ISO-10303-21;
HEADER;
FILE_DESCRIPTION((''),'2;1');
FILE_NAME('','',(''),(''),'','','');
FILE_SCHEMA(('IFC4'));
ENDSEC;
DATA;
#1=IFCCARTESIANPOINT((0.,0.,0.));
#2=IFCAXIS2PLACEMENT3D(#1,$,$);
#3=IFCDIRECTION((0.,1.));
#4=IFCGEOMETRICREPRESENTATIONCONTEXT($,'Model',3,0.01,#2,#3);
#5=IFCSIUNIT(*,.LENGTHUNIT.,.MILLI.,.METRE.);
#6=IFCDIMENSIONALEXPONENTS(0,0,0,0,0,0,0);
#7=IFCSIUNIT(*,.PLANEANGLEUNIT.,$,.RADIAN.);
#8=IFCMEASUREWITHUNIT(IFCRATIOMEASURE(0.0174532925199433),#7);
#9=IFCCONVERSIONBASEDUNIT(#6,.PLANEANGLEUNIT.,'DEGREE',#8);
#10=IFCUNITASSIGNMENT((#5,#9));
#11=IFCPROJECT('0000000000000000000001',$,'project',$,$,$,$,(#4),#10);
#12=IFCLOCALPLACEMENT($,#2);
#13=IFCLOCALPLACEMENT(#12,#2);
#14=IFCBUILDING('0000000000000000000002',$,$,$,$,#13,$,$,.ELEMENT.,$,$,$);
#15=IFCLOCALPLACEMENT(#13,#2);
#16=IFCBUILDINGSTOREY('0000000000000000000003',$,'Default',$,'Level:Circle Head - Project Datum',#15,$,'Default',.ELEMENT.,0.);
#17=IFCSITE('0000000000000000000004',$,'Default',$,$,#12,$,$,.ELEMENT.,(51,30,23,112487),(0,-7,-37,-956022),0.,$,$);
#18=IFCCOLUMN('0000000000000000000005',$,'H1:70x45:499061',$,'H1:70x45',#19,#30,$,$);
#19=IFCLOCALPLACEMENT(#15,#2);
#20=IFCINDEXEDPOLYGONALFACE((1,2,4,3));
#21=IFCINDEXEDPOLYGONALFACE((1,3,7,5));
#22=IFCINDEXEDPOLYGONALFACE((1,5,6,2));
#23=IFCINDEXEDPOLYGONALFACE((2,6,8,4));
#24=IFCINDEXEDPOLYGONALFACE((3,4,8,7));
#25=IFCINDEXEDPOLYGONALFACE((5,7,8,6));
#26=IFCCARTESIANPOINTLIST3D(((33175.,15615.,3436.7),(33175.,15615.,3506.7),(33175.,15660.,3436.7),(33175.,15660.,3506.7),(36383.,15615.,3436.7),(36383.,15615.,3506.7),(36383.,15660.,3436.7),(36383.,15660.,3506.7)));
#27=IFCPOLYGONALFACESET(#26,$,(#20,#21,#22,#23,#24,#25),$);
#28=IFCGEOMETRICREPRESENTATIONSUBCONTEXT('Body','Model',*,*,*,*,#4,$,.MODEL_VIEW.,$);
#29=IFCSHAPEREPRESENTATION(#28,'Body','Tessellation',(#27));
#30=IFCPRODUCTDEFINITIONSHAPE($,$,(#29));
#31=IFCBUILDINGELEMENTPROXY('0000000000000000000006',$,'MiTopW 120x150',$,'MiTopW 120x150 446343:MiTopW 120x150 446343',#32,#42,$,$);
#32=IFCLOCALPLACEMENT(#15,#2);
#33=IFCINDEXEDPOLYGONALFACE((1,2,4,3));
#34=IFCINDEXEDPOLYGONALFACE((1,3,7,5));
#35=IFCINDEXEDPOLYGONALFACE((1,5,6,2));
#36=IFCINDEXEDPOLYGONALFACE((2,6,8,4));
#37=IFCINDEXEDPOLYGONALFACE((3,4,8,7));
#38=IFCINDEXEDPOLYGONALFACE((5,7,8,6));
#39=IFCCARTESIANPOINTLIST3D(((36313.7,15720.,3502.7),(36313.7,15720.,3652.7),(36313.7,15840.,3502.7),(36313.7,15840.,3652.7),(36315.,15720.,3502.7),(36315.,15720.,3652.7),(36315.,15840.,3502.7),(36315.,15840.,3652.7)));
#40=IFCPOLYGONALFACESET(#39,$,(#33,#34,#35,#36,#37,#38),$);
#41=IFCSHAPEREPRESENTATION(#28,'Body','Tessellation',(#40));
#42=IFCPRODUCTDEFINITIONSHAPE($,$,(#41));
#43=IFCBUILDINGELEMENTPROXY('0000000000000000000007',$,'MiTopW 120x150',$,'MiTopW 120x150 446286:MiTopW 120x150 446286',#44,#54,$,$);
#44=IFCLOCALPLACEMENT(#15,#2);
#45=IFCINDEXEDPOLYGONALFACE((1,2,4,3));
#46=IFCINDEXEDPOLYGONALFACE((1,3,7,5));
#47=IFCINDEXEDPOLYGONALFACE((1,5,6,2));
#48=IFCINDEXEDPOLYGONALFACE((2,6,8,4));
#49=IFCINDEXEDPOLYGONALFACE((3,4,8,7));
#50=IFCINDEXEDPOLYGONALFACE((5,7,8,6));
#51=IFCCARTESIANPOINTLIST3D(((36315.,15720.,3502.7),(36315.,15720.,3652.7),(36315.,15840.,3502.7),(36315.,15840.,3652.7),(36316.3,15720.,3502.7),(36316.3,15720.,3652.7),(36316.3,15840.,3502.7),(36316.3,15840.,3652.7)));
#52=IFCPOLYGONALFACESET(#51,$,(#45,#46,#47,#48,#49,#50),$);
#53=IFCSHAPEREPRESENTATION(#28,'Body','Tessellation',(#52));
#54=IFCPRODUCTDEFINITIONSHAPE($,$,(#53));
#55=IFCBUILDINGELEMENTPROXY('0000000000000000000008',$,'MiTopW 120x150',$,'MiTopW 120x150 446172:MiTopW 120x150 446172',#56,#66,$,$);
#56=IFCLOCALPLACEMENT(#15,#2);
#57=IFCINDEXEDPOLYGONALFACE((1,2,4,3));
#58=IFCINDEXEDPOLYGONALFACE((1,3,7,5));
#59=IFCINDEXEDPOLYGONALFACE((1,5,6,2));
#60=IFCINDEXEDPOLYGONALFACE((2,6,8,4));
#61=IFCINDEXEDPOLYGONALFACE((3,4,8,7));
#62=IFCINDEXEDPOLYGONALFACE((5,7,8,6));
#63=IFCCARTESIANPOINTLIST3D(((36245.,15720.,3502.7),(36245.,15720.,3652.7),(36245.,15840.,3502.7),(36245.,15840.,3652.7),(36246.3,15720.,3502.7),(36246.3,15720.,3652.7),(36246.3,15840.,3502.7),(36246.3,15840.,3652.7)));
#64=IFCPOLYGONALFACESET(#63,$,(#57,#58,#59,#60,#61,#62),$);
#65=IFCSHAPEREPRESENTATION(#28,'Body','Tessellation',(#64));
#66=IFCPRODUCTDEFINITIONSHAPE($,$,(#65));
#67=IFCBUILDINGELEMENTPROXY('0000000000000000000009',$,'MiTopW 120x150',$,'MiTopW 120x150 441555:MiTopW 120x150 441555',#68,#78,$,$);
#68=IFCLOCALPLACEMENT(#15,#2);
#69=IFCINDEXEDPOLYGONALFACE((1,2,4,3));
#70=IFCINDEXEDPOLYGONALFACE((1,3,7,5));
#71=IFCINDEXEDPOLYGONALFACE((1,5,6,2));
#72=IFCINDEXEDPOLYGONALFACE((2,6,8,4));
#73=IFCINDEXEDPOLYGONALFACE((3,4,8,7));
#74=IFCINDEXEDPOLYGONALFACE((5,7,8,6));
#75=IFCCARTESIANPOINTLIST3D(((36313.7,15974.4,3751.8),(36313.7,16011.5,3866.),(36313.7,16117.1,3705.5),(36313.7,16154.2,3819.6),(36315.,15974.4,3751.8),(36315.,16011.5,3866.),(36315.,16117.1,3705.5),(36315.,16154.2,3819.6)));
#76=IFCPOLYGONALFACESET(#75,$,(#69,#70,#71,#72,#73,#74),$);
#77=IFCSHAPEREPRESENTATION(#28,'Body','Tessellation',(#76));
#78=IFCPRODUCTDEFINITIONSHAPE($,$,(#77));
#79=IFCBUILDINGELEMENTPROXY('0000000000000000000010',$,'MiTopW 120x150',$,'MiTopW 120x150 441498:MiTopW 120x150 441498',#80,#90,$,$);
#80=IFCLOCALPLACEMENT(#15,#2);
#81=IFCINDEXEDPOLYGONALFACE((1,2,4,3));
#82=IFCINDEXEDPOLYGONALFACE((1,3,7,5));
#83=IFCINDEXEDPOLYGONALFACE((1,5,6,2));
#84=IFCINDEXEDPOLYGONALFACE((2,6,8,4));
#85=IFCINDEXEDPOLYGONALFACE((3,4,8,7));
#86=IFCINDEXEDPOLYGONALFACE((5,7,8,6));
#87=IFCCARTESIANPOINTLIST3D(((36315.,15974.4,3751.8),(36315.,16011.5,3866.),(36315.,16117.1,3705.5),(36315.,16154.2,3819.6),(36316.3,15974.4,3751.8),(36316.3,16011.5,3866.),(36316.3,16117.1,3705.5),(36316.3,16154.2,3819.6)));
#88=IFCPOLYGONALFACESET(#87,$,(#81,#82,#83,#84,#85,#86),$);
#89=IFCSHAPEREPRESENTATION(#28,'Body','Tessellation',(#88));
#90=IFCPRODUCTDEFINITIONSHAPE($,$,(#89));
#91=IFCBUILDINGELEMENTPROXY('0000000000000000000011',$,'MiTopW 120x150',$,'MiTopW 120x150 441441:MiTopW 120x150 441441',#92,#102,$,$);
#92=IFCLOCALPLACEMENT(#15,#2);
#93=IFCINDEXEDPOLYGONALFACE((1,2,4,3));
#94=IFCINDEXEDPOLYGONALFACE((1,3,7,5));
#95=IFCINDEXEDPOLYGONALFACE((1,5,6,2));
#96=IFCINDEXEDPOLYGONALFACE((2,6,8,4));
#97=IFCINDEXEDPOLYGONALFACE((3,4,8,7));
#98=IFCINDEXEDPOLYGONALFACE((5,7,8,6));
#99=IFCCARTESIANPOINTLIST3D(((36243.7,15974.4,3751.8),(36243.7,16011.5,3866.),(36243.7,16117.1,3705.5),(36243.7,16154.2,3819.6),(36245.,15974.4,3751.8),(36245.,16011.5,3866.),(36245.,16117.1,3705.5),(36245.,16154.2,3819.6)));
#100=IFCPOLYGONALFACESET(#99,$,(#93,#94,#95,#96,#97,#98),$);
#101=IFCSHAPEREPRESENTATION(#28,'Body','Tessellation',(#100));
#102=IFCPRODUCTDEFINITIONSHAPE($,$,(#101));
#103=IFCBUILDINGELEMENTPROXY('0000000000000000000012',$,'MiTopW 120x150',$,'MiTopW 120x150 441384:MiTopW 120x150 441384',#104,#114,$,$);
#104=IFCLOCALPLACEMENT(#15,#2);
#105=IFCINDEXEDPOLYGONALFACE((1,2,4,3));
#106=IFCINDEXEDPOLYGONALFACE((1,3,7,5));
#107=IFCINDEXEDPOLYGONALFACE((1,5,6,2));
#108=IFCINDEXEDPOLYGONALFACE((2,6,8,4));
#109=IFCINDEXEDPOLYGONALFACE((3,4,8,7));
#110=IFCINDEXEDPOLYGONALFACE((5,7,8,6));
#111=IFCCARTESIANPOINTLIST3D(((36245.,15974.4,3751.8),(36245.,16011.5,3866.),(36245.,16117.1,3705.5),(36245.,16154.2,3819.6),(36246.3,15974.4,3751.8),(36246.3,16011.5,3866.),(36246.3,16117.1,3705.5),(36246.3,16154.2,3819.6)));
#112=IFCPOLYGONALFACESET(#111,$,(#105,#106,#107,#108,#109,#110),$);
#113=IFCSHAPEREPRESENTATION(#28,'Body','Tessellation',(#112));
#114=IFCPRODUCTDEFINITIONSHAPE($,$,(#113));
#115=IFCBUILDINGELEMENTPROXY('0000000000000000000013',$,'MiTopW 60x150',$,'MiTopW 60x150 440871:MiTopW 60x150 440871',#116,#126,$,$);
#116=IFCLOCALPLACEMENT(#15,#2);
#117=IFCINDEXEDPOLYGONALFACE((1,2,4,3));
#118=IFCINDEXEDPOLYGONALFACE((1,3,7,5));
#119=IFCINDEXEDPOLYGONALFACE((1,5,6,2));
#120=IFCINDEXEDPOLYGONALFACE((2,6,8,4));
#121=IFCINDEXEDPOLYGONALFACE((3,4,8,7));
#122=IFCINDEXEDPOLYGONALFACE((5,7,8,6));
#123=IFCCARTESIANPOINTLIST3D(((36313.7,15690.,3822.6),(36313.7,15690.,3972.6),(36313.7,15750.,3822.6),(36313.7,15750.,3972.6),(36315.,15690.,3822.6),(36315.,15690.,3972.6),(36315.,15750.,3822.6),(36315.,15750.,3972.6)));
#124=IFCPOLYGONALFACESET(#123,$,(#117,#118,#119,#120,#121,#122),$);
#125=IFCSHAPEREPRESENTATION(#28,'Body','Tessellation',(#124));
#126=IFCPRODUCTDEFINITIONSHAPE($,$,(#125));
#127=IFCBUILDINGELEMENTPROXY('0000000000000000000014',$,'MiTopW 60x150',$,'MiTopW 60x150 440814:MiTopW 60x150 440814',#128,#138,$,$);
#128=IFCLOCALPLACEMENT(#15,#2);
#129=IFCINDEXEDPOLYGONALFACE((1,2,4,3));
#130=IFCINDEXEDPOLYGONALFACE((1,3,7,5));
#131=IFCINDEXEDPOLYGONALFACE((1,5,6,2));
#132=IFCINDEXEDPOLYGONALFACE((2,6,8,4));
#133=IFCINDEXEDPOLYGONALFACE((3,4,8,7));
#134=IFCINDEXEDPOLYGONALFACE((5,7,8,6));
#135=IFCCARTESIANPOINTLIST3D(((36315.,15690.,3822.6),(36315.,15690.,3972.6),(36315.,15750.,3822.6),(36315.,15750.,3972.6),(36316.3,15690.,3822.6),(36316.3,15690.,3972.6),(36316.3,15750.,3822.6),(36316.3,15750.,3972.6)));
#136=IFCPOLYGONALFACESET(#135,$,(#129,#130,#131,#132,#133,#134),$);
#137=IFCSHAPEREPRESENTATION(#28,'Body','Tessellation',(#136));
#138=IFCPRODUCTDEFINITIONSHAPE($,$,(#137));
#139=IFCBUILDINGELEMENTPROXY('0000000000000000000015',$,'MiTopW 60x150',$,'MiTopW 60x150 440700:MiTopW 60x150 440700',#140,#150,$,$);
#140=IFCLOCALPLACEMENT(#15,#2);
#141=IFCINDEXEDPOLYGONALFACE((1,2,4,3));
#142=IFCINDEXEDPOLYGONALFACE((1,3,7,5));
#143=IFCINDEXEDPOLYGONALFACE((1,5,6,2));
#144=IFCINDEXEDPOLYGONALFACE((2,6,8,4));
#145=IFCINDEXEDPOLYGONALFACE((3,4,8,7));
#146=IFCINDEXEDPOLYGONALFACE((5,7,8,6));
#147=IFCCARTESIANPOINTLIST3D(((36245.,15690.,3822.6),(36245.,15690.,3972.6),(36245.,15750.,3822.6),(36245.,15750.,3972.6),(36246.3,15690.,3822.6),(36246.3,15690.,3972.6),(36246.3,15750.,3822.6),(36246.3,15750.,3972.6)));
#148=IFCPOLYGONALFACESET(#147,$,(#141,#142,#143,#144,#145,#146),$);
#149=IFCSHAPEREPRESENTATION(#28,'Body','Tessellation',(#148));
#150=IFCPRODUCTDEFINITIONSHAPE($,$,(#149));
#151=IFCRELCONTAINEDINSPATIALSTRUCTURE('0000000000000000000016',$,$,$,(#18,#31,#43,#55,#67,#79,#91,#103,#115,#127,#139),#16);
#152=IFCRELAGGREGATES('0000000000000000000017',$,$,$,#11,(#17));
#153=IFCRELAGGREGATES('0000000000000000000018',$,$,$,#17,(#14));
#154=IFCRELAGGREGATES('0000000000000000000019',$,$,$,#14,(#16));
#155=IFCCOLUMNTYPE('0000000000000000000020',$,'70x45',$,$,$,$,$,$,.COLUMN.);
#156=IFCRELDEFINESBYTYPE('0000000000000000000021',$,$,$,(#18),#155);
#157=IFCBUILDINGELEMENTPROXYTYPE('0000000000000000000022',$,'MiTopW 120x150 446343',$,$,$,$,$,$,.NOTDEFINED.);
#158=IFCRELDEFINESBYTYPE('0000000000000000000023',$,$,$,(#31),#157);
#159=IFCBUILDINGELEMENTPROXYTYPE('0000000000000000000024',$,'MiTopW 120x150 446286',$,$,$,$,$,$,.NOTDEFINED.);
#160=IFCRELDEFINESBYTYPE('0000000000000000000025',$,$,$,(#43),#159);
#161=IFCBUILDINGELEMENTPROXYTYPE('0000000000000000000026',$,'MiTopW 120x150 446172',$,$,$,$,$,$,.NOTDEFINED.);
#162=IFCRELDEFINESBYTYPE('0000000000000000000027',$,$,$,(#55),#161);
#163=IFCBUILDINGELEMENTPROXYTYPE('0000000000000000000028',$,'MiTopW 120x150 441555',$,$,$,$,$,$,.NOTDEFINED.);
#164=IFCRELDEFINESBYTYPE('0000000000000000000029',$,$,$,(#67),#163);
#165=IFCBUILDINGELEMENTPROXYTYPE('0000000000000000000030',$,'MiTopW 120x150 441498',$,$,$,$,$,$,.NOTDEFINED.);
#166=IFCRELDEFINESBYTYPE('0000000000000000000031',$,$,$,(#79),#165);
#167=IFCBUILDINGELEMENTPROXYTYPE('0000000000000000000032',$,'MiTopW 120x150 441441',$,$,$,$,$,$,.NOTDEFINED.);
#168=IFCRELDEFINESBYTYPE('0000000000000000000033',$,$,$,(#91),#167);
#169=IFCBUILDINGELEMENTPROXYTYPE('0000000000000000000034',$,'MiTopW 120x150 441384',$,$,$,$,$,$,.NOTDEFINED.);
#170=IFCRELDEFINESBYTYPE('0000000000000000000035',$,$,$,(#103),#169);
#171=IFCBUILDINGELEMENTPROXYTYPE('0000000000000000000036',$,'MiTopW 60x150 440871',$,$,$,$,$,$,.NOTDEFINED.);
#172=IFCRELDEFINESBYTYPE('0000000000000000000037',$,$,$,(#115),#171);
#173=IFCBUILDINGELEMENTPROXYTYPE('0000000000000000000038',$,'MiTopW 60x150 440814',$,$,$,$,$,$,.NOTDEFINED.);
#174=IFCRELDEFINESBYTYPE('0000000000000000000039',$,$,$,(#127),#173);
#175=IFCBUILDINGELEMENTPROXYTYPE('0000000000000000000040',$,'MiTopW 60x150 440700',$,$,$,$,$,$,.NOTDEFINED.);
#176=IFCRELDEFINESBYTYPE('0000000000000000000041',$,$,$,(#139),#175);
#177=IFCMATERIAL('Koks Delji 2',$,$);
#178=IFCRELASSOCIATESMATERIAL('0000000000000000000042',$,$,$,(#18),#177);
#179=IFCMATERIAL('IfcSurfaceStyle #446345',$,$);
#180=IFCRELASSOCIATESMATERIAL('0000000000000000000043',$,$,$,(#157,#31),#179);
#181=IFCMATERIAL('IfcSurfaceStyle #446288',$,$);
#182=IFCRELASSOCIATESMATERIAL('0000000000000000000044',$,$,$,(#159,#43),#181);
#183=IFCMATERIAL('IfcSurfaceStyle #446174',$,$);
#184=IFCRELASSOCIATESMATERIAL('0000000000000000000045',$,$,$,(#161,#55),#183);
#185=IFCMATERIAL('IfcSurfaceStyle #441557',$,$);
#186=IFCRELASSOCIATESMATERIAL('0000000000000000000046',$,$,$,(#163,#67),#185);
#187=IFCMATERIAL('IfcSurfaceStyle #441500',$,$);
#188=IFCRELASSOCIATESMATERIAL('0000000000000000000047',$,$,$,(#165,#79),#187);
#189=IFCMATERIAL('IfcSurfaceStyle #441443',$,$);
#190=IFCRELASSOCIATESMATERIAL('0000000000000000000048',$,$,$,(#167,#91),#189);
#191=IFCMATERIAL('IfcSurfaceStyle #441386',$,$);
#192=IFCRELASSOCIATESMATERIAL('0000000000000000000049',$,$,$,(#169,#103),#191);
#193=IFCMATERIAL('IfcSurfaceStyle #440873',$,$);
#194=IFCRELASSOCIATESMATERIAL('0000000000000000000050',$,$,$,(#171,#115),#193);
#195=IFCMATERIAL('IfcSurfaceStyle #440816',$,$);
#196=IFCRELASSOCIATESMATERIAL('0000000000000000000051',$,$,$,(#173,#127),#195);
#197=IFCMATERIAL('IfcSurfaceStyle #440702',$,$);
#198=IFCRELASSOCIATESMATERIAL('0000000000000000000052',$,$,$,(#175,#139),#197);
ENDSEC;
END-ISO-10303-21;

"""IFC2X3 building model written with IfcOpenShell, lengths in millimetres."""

from ifc_helpers import new_model, entity, si_unit, converted_unit, direction, frame, frame_2d, origin, origin_2d_with_axis, place, context, subcontext, project, spatial, polyline, rectangle, outline, extrude, source, transform, mapped, material, type_object, type_shapes, element, save


model = new_model("IFC2X3")

# Units and contexts
model_context = context("Model", 3, precision=0.01, world=origin(), true_north=direction((0.0, 1.0)))
body_context = subcontext(model_context, "Body", "Model", "MODEL_VIEW")
ifc_project = project(units=[si_unit("LENGTHUNIT", "METRE", prefix="MILLI"), converted_unit("PLANEANGLEUNIT", "DEGREE", entity("IfcRatioMeasure", 0.0174532925199433), si_unit("PLANEANGLEUNIT", "RADIAN"), dimensions=[0, 0, 0, 0, 0, 0, 0])], contexts=[model_context])

# Site, building, storey
site_placement = place(None, origin())
site = spatial("IfcSite", under=ifc_project, at=site_placement, Name="Default", CompositionType="ELEMENT", RefLatitude=(51, 30, 23, 112487), RefLongitude=(0, -7, -37, -956022), RefElevation=0.0)
building_placement = place(site_placement, origin())
building = spatial("IfcBuilding", under=site, at=building_placement, CompositionType="ELEMENT")
storey_placement = place(building_placement, origin())
storey = spatial("IfcBuildingStorey", under=building, at=storey_placement, Name="Default", ObjectType="Level:Circle Head - Project Datum", LongName="Default", CompositionType="ELEMENT", Elevation=0.0)

# Column
ifc_material_1 = material(Name="Koks Delji 2")
column_type = type_object("IfcColumnType", Name="70x45", PredefinedType="COLUMN")
shared_shape_1 = source(origin(), body_context, "Body", "SweptSolid", [
    extrude(rectangle(XDim=45.0, YDim=3208.0, at=frame_2d((0.0, 0.0), x_axis=(1.0, 0.0))), frame((1604.0, 250.3, 0.0), z_axis=(0.0, 0.0, 1.0), x_axis=(0.0, -1.0, 0.0)), (0.0, 0.0, 1.0), 70.0),
])
type_shapes(column_type, [shared_shape_1])
column_placement = place(storey_placement, frame((36383.0, 15887.8, 3436.7), z_axis=(0.0, 0.0, 1.0), x_axis=(-1.0, 0.0, 0.0)))
element("IfcColumn", 1, at=column_placement, inside=storey, type_object=column_type, material=ifc_material_1, Name="H1:70x45:499061", ObjectType="H1:70x45", context=body_context, shape_type="MappedRepresentation", body=[
    mapped(shared_shape_1, transform((0.0, 0.0, 0.0), scale=1.0)),
])

# Building element proxies
ifc_material_2 = material(Name="IfcSurfaceStyle #446345")
building_element_proxy_type_1 = type_object("IfcBuildingElementProxyType", Name="MiTopW 120x150 446343", PredefinedType="NOTDEFINED", material=ifc_material_2)
shared_shape_2 = source(origin(), body_context, "Body", "SweptSolid", [
    extrude(rectangle(XDim=150.0, YDim=120.0, at=origin_2d_with_axis()), frame((75.0, 60.0, 0.0), z_axis=(0.0, 0.0, 1.0), x_axis=(-1.0, 0.0, 0.0)), (0.0, 0.0, 1.0), 1.3),
])
type_shapes(building_element_proxy_type_1, [shared_shape_2])
proxy_1_placement = place(building_placement, frame((36315.0, 15840.0, 3652.7), z_axis=(-1.0, 0.0, 0.0), x_axis=(0.0, 0.0, -1.0)))
element("IfcBuildingElementProxy", 2, at=proxy_1_placement, inside=storey, type_object=building_element_proxy_type_1, material=ifc_material_2, Name="MiTopW 120x150", ObjectType="MiTopW 120x150 446343:MiTopW 120x150 446343", context=body_context, shape_type="MappedRepresentation", body=[
    mapped(shared_shape_2, transform((0.0, 0.0, 0.0), scale=1.0)),
])
ifc_material_3 = material(Name="IfcSurfaceStyle #446288")
building_element_proxy_type_2 = type_object("IfcBuildingElementProxyType", Name="MiTopW 120x150 446286", PredefinedType="NOTDEFINED", material=ifc_material_3)
shared_shape_3 = source(origin(), body_context, "Body", "SweptSolid", [
    extrude(rectangle(XDim=150.0, YDim=120.0, at=origin_2d_with_axis()), frame((75.0, 60.0, 0.0), z_axis=(0.0, 0.0, 1.0), x_axis=(-1.0, 0.0, 0.0)), (0.0, 0.0, 1.0), 1.3),
])
type_shapes(building_element_proxy_type_2, [shared_shape_3])
proxy_2_placement = place(building_placement, frame((36316.3, 15840.0, 3652.7), z_axis=(-1.0, 0.0, 0.0), x_axis=(0.0, 0.0, -1.0)))
element("IfcBuildingElementProxy", 3, at=proxy_2_placement, inside=storey, type_object=building_element_proxy_type_2, material=ifc_material_3, Name="MiTopW 120x150", ObjectType="MiTopW 120x150 446286:MiTopW 120x150 446286", context=body_context, shape_type="MappedRepresentation", body=[
    mapped(shared_shape_3, transform((0.0, 0.0, 0.0), scale=1.0)),
])
ifc_material_4 = material(Name="IfcSurfaceStyle #446174")
building_element_proxy_type_3 = type_object("IfcBuildingElementProxyType", Name="MiTopW 120x150 446172", PredefinedType="NOTDEFINED", material=ifc_material_4)
shared_shape_4 = source(origin(), body_context, "Body", "SweptSolid", [
    extrude(rectangle(XDim=150.0, YDim=120.0, at=origin_2d_with_axis()), frame((75.0, 60.0, 0.0), z_axis=(0.0, 0.0, 1.0), x_axis=(-1.0, 0.0, 0.0)), (0.0, 0.0, 1.0), 1.3),
])
type_shapes(building_element_proxy_type_3, [shared_shape_4])
proxy_3_placement = place(building_placement, frame((36246.3, 15840.0, 3652.7), z_axis=(-1.0, 0.0, 0.0), x_axis=(0.0, 0.0, -1.0)))
element("IfcBuildingElementProxy", 4, at=proxy_3_placement, inside=storey, type_object=building_element_proxy_type_3, material=ifc_material_4, Name="MiTopW 120x150", ObjectType="MiTopW 120x150 446172:MiTopW 120x150 446172", context=body_context, shape_type="MappedRepresentation", body=[
    mapped(shared_shape_4, transform((0.0, 0.0, 0.0), scale=1.0)),
])
ifc_material_5 = material(Name="IfcSurfaceStyle #441557")
building_element_proxy_type_4 = type_object("IfcBuildingElementProxyType", Name="MiTopW 120x150 441555", PredefinedType="NOTDEFINED", material=ifc_material_5)
shared_shape_5 = source(origin(), body_context, "Body", "SweptSolid", [
    extrude(outline(polyline([(-75.0, -60.0), (75.0, -60.0), (75.0, 60.0), (-75.0, 60.0), (-75.0, -60.0)])), frame((75.0, 60.0, 0.0), z_axis=(0.0, 0.0, 1.0), x_axis=(-1.0, 0.0, 0.0)), (0.0, 0.0, 1.0), 1.3),
])
type_shapes(building_element_proxy_type_4, [shared_shape_5])
proxy_4_placement = place(building_placement, frame((36315.0, 16117.1, 3705.5), z_axis=(-1.0, 0.0, 0.0), x_axis=(0.0, -0.951057, 0.309017)))
element("IfcBuildingElementProxy", 5, at=proxy_4_placement, inside=storey, type_object=building_element_proxy_type_4, material=ifc_material_5, Name="MiTopW 120x150", ObjectType="MiTopW 120x150 441555:MiTopW 120x150 441555", context=body_context, shape_type="MappedRepresentation", body=[
    mapped(shared_shape_5, transform((0.0, 0.0, 0.0), scale=1.0)),
])
ifc_material_6 = material(Name="IfcSurfaceStyle #441500")
building_element_proxy_type_5 = type_object("IfcBuildingElementProxyType", Name="MiTopW 120x150 441498", PredefinedType="NOTDEFINED", material=ifc_material_6)
shared_shape_6 = source(origin(), body_context, "Body", "SweptSolid", [
    extrude(outline(polyline([(-75.0, -60.0), (75.0, -60.0), (75.0, 60.0), (-75.0, 60.0), (-75.0, -60.0)])), frame((75.0, 60.0, 0.0), z_axis=(0.0, 0.0, 1.0), x_axis=(-1.0, 0.0, 0.0)), (0.0, 0.0, 1.0), 1.3),
])
type_shapes(building_element_proxy_type_5, [shared_shape_6])
proxy_5_placement = place(building_placement, frame((36316.3, 16117.1, 3705.5), z_axis=(-1.0, 0.0, 0.0), x_axis=(0.0, -0.951057, 0.309017)))
element("IfcBuildingElementProxy", 6, at=proxy_5_placement, inside=storey, type_object=building_element_proxy_type_5, material=ifc_material_6, Name="MiTopW 120x150", ObjectType="MiTopW 120x150 441498:MiTopW 120x150 441498", context=body_context, shape_type="MappedRepresentation", body=[
    mapped(shared_shape_6, transform((0.0, 0.0, 0.0), scale=1.0)),
])
ifc_material_7 = material(Name="IfcSurfaceStyle #441443")
building_element_proxy_type_6 = type_object("IfcBuildingElementProxyType", Name="MiTopW 120x150 441441", PredefinedType="NOTDEFINED", material=ifc_material_7)
shared_shape_7 = source(origin(), body_context, "Body", "SweptSolid", [
    extrude(outline(polyline([(-75.0, -60.0), (75.0, -60.0), (75.0, 60.0), (-75.0, 60.0), (-75.0, -60.0)])), frame((75.0, 60.0, 0.0), z_axis=(0.0, 0.0, 1.0), x_axis=(-1.0, 0.0, 0.0)), (0.0, 0.0, 1.0), 1.3),
])
type_shapes(building_element_proxy_type_6, [shared_shape_7])
proxy_6_placement = place(building_placement, frame((36245.0, 16117.1, 3705.5), z_axis=(-1.0, 0.0, 0.0), x_axis=(0.0, -0.951057, 0.309017)))
element("IfcBuildingElementProxy", 7, at=proxy_6_placement, inside=storey, type_object=building_element_proxy_type_6, material=ifc_material_7, Name="MiTopW 120x150", ObjectType="MiTopW 120x150 441441:MiTopW 120x150 441441", context=body_context, shape_type="MappedRepresentation", body=[
    mapped(shared_shape_7, transform((0.0, 0.0, 0.0), scale=1.0)),
])
ifc_material_8 = material(Name="IfcSurfaceStyle #441386")
building_element_proxy_type_7 = type_object("IfcBuildingElementProxyType", Name="MiTopW 120x150 441384", PredefinedType="NOTDEFINED", material=ifc_material_8)
shared_shape_8 = source(origin(), body_context, "Body", "SweptSolid", [
    extrude(outline(polyline([(-75.0, -60.0), (75.0, -60.0), (75.0, 60.0), (-75.0, 60.0), (-75.0, -60.0)])), frame((75.0, 60.0, 0.0), z_axis=(0.0, 0.0, 1.0), x_axis=(-1.0, 0.0, 0.0)), (0.0, 0.0, 1.0), 1.3),
])
type_shapes(building_element_proxy_type_7, [shared_shape_8])
proxy_7_placement = place(building_placement, frame((36246.3, 16117.1, 3705.5), z_axis=(-1.0, 0.0, 0.0), x_axis=(0.0, -0.951057, 0.309017)))
element("IfcBuildingElementProxy", 8, at=proxy_7_placement, inside=storey, type_object=building_element_proxy_type_7, material=ifc_material_8, Name="MiTopW 120x150", ObjectType="MiTopW 120x150 441384:MiTopW 120x150 441384", context=body_context, shape_type="MappedRepresentation", body=[
    mapped(shared_shape_8, transform((0.0, 0.0, 0.0), scale=1.0)),
])
ifc_material_9 = material(Name="IfcSurfaceStyle #440873")
building_element_proxy_type_8 = type_object("IfcBuildingElementProxyType", Name="MiTopW 60x150 440871", PredefinedType="NOTDEFINED", material=ifc_material_9)
shared_shape_9 = source(origin(), body_context, "Body", "SweptSolid", [
    extrude(rectangle(XDim=150.0, YDim=60.0, at=origin_2d_with_axis()), frame((75.0, 30.0, 0.0), z_axis=(0.0, 0.0, 1.0), x_axis=(-1.0, 0.0, 0.0)), (0.0, 0.0, 1.0), 1.3),
])
type_shapes(building_element_proxy_type_8, [shared_shape_9])
proxy_8_placement = place(building_placement, frame((36315.0, 15750.0, 3972.6), z_axis=(-1.0, 0.0, 0.0), x_axis=(0.0, 0.0, -1.0)))
element("IfcBuildingElementProxy", 9, at=proxy_8_placement, inside=storey, type_object=building_element_proxy_type_8, material=ifc_material_9, Name="MiTopW 60x150", ObjectType="MiTopW 60x150 440871:MiTopW 60x150 440871", context=body_context, shape_type="MappedRepresentation", body=[
    mapped(shared_shape_9, transform((0.0, 0.0, 0.0), scale=1.0)),
])
ifc_material_10 = material(Name="IfcSurfaceStyle #440816")
building_element_proxy_type_9 = type_object("IfcBuildingElementProxyType", Name="MiTopW 60x150 440814", PredefinedType="NOTDEFINED", material=ifc_material_10)
shared_shape_10 = source(origin(), body_context, "Body", "SweptSolid", [
    extrude(rectangle(XDim=150.0, YDim=60.0, at=origin_2d_with_axis()), frame((75.0, 30.0, 0.0), z_axis=(0.0, 0.0, 1.0), x_axis=(-1.0, 0.0, 0.0)), (0.0, 0.0, 1.0), 1.3),
])
type_shapes(building_element_proxy_type_9, [shared_shape_10])
proxy_9_placement = place(building_placement, frame((36316.3, 15750.0, 3972.6), z_axis=(-1.0, 0.0, 0.0), x_axis=(0.0, 0.0, -1.0)))
element("IfcBuildingElementProxy", 10, at=proxy_9_placement, inside=storey, type_object=building_element_proxy_type_9, material=ifc_material_10, Name="MiTopW 60x150", ObjectType="MiTopW 60x150 440814:MiTopW 60x150 440814", context=body_context, shape_type="MappedRepresentation", body=[
    mapped(shared_shape_10, transform((0.0, 0.0, 0.0), scale=1.0)),
])
ifc_material_11 = material(Name="IfcSurfaceStyle #440702")
building_element_proxy_type_10 = type_object("IfcBuildingElementProxyType", Name="MiTopW 60x150 440700", PredefinedType="NOTDEFINED", material=ifc_material_11)
shared_shape_11 = source(origin(), body_context, "Body", "SweptSolid", [
    extrude(rectangle(XDim=150.0, YDim=60.0, at=origin_2d_with_axis()), frame((75.0, 30.0, 0.0), z_axis=(0.0, 0.0, 1.0), x_axis=(-1.0, 0.0, 0.0)), (0.0, 0.0, 1.0), 1.3),
])
type_shapes(building_element_proxy_type_10, [shared_shape_11])
proxy_10_placement = place(building_placement, frame((36246.3, 15750.0, 3972.6), z_axis=(-1.0, 0.0, 0.0), x_axis=(0.0, 0.0, -1.0)))
element("IfcBuildingElementProxy", 11, at=proxy_10_placement, inside=storey, type_object=building_element_proxy_type_10, material=ifc_material_11, Name="MiTopW 60x150", ObjectType="MiTopW 60x150 440700:MiTopW 60x150 440700", context=body_context, shape_type="MappedRepresentation", body=[
    mapped(shared_shape_11, transform((0.0, 0.0, 0.0), scale=1.0)),
])

save(model, "model.ifc")
